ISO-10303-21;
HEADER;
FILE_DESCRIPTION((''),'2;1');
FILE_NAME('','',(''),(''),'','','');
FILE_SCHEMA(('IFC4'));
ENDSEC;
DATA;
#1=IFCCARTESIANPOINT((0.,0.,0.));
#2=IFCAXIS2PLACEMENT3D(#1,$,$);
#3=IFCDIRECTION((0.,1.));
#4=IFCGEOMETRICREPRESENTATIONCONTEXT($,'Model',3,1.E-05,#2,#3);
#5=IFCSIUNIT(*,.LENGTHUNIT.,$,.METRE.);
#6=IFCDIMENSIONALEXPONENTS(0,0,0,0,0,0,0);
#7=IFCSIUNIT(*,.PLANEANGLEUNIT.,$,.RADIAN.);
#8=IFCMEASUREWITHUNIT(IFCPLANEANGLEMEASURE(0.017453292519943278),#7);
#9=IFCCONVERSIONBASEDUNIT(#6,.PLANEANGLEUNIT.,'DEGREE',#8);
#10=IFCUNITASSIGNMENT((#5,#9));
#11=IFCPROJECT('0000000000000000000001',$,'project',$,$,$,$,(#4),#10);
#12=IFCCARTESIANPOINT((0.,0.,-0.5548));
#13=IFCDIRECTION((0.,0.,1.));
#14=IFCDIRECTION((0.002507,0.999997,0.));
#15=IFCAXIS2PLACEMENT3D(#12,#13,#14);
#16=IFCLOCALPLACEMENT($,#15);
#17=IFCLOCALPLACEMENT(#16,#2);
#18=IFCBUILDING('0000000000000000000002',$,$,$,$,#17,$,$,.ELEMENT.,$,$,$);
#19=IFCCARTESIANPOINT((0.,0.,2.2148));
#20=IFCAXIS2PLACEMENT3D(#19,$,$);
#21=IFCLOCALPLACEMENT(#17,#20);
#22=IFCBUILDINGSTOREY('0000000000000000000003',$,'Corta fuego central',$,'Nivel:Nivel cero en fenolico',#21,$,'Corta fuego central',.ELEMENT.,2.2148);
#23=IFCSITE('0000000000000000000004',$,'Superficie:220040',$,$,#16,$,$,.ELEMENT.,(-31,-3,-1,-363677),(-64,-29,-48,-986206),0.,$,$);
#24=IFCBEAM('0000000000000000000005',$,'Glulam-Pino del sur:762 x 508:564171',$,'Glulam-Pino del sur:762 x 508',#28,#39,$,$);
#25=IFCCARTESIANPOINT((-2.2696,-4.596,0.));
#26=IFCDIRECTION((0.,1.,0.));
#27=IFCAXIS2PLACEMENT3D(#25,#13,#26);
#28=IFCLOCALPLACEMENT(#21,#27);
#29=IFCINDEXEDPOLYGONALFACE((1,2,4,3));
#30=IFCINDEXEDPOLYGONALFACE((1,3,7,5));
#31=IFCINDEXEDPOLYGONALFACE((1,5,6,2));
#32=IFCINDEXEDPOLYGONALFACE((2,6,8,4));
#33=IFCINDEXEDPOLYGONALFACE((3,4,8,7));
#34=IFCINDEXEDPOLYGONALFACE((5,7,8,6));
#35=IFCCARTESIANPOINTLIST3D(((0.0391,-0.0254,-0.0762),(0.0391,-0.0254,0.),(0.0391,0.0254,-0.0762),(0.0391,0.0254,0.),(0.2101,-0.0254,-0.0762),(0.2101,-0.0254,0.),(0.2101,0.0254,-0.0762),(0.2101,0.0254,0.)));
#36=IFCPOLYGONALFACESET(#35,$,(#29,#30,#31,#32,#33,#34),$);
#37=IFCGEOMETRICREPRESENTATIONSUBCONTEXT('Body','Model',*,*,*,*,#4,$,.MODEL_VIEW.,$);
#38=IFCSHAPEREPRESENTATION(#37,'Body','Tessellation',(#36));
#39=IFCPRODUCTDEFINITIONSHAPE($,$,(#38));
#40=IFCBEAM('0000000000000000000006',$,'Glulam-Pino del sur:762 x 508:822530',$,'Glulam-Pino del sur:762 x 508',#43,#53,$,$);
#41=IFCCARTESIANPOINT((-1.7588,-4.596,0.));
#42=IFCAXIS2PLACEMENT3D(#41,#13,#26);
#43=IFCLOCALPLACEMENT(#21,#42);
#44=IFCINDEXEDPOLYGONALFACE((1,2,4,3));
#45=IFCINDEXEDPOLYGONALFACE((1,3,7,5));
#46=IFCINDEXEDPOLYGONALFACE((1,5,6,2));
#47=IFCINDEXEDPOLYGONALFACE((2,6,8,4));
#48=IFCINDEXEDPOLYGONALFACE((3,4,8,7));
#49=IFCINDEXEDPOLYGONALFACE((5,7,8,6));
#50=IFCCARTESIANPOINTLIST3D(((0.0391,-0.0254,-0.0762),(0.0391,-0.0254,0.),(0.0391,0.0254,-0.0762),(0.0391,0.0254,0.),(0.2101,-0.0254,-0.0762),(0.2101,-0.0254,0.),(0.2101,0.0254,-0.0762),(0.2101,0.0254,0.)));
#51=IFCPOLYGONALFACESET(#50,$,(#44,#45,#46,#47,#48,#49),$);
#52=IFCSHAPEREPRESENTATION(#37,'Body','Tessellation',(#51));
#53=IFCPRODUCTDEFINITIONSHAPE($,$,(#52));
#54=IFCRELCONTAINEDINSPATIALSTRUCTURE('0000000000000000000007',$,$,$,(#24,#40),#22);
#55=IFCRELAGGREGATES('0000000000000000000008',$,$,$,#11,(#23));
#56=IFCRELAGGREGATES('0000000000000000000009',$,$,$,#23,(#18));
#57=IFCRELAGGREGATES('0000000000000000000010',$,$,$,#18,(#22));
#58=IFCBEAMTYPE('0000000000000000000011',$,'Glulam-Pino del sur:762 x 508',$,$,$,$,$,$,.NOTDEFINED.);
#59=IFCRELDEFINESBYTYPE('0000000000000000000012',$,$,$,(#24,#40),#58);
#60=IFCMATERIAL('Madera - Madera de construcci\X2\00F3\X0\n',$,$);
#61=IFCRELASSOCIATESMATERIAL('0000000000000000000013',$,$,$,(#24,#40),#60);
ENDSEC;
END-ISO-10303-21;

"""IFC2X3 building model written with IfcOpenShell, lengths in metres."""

from ifc_helpers import new_model, entity, si_unit, converted_unit, direction, frame, origin, origin_2d_with_axis, place, context, subcontext, project, spatial, rectangle, extrude, material, type_object, element, save


model = new_model("IFC2X3")

# Units and contexts
model_context = context("Model", 3, precision=1e-05, world=origin(), true_north=direction((0.0, 1.0)))
body_context = subcontext(model_context, "Body", "Model", "MODEL_VIEW")
ifc_project = project(units=[si_unit("LENGTHUNIT", "METRE"), converted_unit("PLANEANGLEUNIT", "DEGREE", entity("IfcPlaneAngleMeasure", 0.017453292519943278), si_unit("PLANEANGLEUNIT", "RADIAN"), dimensions=[0, 0, 0, 0, 0, 0, 0])], contexts=[model_context])

# Site, building, storey
site_placement = place(None, frame((0.0, 0.0, -0.5548), z_axis=(0.0, 0.0, 1.0), x_axis=(0.002507, 0.999997, 0.0)))
site = spatial("IfcSite", under=ifc_project, at=site_placement, Name="Superficie:220040", CompositionType="ELEMENT", RefLatitude=(-31, -3, -1, -363677), RefLongitude=(-64, -29, -48, -986206), RefElevation=0.0)
building_placement = place(site_placement, origin())
building = spatial("IfcBuilding", under=site, at=building_placement, CompositionType="ELEMENT")
storey_placement = place(building_placement, frame((0.0, 0.0, 2.2148)))
storey = spatial("IfcBuildingStorey", under=building, at=storey_placement, Name="Corta fuego central", ObjectType="Nivel:Nivel cero en fenolico", LongName="Corta fuego central", CompositionType="ELEMENT", Elevation=2.2148)

# Shared definitions
ifc_material_1 = material(Name="Madera - Madera de construcción")

# Beams
beam_type_1 = type_object("IfcBeamType", Name="Glulam-Pino del sur:762 x 508", PredefinedType="NOTDEFINED")
beam_1_placement = place(storey_placement, frame((-2.2696, -4.596, 0.0), z_axis=(0.0, 0.0, 1.0), x_axis=(0.0, 1.0, 0.0)))
element("IfcBeam", 1, at=beam_1_placement, inside=storey, type_object=beam_type_1, material=ifc_material_1, Name="Glulam-Pino del sur:762 x 508:564171", ObjectType="Glulam-Pino del sur:762 x 508", context=body_context, shape_type="SweptSolid", body=[
    extrude(rectangle(XDim=0.0762, YDim=0.0508, at=origin_2d_with_axis()), frame((0.0391, 0.0, -0.0381), z_axis=(1.0, 0.0, 0.0), x_axis=(0.0, 0.0, -1.0)), (0.0, 0.0, 1.0), 0.171),
])
beam_2_placement = place(storey_placement, frame((-1.7588, -4.596, 0.0), z_axis=(0.0, 0.0, 1.0), x_axis=(0.0, 1.0, 0.0)))
element("IfcBeam", 2, at=beam_2_placement, inside=storey, type_object=beam_type_1, material=ifc_material_1, Name="Glulam-Pino del sur:762 x 508:822530", ObjectType="Glulam-Pino del sur:762 x 508", context=body_context, shape_type="SweptSolid", body=[
    extrude(rectangle(XDim=0.0762, YDim=0.0508, at=origin_2d_with_axis()), frame((0.0391, 0.0, -0.0381), z_axis=(1.0, 0.0, 0.0), x_axis=(0.0, 0.0, -1.0)), (0.0, 0.0, 1.0), 0.171),
])

save(model, "model.ifc")
